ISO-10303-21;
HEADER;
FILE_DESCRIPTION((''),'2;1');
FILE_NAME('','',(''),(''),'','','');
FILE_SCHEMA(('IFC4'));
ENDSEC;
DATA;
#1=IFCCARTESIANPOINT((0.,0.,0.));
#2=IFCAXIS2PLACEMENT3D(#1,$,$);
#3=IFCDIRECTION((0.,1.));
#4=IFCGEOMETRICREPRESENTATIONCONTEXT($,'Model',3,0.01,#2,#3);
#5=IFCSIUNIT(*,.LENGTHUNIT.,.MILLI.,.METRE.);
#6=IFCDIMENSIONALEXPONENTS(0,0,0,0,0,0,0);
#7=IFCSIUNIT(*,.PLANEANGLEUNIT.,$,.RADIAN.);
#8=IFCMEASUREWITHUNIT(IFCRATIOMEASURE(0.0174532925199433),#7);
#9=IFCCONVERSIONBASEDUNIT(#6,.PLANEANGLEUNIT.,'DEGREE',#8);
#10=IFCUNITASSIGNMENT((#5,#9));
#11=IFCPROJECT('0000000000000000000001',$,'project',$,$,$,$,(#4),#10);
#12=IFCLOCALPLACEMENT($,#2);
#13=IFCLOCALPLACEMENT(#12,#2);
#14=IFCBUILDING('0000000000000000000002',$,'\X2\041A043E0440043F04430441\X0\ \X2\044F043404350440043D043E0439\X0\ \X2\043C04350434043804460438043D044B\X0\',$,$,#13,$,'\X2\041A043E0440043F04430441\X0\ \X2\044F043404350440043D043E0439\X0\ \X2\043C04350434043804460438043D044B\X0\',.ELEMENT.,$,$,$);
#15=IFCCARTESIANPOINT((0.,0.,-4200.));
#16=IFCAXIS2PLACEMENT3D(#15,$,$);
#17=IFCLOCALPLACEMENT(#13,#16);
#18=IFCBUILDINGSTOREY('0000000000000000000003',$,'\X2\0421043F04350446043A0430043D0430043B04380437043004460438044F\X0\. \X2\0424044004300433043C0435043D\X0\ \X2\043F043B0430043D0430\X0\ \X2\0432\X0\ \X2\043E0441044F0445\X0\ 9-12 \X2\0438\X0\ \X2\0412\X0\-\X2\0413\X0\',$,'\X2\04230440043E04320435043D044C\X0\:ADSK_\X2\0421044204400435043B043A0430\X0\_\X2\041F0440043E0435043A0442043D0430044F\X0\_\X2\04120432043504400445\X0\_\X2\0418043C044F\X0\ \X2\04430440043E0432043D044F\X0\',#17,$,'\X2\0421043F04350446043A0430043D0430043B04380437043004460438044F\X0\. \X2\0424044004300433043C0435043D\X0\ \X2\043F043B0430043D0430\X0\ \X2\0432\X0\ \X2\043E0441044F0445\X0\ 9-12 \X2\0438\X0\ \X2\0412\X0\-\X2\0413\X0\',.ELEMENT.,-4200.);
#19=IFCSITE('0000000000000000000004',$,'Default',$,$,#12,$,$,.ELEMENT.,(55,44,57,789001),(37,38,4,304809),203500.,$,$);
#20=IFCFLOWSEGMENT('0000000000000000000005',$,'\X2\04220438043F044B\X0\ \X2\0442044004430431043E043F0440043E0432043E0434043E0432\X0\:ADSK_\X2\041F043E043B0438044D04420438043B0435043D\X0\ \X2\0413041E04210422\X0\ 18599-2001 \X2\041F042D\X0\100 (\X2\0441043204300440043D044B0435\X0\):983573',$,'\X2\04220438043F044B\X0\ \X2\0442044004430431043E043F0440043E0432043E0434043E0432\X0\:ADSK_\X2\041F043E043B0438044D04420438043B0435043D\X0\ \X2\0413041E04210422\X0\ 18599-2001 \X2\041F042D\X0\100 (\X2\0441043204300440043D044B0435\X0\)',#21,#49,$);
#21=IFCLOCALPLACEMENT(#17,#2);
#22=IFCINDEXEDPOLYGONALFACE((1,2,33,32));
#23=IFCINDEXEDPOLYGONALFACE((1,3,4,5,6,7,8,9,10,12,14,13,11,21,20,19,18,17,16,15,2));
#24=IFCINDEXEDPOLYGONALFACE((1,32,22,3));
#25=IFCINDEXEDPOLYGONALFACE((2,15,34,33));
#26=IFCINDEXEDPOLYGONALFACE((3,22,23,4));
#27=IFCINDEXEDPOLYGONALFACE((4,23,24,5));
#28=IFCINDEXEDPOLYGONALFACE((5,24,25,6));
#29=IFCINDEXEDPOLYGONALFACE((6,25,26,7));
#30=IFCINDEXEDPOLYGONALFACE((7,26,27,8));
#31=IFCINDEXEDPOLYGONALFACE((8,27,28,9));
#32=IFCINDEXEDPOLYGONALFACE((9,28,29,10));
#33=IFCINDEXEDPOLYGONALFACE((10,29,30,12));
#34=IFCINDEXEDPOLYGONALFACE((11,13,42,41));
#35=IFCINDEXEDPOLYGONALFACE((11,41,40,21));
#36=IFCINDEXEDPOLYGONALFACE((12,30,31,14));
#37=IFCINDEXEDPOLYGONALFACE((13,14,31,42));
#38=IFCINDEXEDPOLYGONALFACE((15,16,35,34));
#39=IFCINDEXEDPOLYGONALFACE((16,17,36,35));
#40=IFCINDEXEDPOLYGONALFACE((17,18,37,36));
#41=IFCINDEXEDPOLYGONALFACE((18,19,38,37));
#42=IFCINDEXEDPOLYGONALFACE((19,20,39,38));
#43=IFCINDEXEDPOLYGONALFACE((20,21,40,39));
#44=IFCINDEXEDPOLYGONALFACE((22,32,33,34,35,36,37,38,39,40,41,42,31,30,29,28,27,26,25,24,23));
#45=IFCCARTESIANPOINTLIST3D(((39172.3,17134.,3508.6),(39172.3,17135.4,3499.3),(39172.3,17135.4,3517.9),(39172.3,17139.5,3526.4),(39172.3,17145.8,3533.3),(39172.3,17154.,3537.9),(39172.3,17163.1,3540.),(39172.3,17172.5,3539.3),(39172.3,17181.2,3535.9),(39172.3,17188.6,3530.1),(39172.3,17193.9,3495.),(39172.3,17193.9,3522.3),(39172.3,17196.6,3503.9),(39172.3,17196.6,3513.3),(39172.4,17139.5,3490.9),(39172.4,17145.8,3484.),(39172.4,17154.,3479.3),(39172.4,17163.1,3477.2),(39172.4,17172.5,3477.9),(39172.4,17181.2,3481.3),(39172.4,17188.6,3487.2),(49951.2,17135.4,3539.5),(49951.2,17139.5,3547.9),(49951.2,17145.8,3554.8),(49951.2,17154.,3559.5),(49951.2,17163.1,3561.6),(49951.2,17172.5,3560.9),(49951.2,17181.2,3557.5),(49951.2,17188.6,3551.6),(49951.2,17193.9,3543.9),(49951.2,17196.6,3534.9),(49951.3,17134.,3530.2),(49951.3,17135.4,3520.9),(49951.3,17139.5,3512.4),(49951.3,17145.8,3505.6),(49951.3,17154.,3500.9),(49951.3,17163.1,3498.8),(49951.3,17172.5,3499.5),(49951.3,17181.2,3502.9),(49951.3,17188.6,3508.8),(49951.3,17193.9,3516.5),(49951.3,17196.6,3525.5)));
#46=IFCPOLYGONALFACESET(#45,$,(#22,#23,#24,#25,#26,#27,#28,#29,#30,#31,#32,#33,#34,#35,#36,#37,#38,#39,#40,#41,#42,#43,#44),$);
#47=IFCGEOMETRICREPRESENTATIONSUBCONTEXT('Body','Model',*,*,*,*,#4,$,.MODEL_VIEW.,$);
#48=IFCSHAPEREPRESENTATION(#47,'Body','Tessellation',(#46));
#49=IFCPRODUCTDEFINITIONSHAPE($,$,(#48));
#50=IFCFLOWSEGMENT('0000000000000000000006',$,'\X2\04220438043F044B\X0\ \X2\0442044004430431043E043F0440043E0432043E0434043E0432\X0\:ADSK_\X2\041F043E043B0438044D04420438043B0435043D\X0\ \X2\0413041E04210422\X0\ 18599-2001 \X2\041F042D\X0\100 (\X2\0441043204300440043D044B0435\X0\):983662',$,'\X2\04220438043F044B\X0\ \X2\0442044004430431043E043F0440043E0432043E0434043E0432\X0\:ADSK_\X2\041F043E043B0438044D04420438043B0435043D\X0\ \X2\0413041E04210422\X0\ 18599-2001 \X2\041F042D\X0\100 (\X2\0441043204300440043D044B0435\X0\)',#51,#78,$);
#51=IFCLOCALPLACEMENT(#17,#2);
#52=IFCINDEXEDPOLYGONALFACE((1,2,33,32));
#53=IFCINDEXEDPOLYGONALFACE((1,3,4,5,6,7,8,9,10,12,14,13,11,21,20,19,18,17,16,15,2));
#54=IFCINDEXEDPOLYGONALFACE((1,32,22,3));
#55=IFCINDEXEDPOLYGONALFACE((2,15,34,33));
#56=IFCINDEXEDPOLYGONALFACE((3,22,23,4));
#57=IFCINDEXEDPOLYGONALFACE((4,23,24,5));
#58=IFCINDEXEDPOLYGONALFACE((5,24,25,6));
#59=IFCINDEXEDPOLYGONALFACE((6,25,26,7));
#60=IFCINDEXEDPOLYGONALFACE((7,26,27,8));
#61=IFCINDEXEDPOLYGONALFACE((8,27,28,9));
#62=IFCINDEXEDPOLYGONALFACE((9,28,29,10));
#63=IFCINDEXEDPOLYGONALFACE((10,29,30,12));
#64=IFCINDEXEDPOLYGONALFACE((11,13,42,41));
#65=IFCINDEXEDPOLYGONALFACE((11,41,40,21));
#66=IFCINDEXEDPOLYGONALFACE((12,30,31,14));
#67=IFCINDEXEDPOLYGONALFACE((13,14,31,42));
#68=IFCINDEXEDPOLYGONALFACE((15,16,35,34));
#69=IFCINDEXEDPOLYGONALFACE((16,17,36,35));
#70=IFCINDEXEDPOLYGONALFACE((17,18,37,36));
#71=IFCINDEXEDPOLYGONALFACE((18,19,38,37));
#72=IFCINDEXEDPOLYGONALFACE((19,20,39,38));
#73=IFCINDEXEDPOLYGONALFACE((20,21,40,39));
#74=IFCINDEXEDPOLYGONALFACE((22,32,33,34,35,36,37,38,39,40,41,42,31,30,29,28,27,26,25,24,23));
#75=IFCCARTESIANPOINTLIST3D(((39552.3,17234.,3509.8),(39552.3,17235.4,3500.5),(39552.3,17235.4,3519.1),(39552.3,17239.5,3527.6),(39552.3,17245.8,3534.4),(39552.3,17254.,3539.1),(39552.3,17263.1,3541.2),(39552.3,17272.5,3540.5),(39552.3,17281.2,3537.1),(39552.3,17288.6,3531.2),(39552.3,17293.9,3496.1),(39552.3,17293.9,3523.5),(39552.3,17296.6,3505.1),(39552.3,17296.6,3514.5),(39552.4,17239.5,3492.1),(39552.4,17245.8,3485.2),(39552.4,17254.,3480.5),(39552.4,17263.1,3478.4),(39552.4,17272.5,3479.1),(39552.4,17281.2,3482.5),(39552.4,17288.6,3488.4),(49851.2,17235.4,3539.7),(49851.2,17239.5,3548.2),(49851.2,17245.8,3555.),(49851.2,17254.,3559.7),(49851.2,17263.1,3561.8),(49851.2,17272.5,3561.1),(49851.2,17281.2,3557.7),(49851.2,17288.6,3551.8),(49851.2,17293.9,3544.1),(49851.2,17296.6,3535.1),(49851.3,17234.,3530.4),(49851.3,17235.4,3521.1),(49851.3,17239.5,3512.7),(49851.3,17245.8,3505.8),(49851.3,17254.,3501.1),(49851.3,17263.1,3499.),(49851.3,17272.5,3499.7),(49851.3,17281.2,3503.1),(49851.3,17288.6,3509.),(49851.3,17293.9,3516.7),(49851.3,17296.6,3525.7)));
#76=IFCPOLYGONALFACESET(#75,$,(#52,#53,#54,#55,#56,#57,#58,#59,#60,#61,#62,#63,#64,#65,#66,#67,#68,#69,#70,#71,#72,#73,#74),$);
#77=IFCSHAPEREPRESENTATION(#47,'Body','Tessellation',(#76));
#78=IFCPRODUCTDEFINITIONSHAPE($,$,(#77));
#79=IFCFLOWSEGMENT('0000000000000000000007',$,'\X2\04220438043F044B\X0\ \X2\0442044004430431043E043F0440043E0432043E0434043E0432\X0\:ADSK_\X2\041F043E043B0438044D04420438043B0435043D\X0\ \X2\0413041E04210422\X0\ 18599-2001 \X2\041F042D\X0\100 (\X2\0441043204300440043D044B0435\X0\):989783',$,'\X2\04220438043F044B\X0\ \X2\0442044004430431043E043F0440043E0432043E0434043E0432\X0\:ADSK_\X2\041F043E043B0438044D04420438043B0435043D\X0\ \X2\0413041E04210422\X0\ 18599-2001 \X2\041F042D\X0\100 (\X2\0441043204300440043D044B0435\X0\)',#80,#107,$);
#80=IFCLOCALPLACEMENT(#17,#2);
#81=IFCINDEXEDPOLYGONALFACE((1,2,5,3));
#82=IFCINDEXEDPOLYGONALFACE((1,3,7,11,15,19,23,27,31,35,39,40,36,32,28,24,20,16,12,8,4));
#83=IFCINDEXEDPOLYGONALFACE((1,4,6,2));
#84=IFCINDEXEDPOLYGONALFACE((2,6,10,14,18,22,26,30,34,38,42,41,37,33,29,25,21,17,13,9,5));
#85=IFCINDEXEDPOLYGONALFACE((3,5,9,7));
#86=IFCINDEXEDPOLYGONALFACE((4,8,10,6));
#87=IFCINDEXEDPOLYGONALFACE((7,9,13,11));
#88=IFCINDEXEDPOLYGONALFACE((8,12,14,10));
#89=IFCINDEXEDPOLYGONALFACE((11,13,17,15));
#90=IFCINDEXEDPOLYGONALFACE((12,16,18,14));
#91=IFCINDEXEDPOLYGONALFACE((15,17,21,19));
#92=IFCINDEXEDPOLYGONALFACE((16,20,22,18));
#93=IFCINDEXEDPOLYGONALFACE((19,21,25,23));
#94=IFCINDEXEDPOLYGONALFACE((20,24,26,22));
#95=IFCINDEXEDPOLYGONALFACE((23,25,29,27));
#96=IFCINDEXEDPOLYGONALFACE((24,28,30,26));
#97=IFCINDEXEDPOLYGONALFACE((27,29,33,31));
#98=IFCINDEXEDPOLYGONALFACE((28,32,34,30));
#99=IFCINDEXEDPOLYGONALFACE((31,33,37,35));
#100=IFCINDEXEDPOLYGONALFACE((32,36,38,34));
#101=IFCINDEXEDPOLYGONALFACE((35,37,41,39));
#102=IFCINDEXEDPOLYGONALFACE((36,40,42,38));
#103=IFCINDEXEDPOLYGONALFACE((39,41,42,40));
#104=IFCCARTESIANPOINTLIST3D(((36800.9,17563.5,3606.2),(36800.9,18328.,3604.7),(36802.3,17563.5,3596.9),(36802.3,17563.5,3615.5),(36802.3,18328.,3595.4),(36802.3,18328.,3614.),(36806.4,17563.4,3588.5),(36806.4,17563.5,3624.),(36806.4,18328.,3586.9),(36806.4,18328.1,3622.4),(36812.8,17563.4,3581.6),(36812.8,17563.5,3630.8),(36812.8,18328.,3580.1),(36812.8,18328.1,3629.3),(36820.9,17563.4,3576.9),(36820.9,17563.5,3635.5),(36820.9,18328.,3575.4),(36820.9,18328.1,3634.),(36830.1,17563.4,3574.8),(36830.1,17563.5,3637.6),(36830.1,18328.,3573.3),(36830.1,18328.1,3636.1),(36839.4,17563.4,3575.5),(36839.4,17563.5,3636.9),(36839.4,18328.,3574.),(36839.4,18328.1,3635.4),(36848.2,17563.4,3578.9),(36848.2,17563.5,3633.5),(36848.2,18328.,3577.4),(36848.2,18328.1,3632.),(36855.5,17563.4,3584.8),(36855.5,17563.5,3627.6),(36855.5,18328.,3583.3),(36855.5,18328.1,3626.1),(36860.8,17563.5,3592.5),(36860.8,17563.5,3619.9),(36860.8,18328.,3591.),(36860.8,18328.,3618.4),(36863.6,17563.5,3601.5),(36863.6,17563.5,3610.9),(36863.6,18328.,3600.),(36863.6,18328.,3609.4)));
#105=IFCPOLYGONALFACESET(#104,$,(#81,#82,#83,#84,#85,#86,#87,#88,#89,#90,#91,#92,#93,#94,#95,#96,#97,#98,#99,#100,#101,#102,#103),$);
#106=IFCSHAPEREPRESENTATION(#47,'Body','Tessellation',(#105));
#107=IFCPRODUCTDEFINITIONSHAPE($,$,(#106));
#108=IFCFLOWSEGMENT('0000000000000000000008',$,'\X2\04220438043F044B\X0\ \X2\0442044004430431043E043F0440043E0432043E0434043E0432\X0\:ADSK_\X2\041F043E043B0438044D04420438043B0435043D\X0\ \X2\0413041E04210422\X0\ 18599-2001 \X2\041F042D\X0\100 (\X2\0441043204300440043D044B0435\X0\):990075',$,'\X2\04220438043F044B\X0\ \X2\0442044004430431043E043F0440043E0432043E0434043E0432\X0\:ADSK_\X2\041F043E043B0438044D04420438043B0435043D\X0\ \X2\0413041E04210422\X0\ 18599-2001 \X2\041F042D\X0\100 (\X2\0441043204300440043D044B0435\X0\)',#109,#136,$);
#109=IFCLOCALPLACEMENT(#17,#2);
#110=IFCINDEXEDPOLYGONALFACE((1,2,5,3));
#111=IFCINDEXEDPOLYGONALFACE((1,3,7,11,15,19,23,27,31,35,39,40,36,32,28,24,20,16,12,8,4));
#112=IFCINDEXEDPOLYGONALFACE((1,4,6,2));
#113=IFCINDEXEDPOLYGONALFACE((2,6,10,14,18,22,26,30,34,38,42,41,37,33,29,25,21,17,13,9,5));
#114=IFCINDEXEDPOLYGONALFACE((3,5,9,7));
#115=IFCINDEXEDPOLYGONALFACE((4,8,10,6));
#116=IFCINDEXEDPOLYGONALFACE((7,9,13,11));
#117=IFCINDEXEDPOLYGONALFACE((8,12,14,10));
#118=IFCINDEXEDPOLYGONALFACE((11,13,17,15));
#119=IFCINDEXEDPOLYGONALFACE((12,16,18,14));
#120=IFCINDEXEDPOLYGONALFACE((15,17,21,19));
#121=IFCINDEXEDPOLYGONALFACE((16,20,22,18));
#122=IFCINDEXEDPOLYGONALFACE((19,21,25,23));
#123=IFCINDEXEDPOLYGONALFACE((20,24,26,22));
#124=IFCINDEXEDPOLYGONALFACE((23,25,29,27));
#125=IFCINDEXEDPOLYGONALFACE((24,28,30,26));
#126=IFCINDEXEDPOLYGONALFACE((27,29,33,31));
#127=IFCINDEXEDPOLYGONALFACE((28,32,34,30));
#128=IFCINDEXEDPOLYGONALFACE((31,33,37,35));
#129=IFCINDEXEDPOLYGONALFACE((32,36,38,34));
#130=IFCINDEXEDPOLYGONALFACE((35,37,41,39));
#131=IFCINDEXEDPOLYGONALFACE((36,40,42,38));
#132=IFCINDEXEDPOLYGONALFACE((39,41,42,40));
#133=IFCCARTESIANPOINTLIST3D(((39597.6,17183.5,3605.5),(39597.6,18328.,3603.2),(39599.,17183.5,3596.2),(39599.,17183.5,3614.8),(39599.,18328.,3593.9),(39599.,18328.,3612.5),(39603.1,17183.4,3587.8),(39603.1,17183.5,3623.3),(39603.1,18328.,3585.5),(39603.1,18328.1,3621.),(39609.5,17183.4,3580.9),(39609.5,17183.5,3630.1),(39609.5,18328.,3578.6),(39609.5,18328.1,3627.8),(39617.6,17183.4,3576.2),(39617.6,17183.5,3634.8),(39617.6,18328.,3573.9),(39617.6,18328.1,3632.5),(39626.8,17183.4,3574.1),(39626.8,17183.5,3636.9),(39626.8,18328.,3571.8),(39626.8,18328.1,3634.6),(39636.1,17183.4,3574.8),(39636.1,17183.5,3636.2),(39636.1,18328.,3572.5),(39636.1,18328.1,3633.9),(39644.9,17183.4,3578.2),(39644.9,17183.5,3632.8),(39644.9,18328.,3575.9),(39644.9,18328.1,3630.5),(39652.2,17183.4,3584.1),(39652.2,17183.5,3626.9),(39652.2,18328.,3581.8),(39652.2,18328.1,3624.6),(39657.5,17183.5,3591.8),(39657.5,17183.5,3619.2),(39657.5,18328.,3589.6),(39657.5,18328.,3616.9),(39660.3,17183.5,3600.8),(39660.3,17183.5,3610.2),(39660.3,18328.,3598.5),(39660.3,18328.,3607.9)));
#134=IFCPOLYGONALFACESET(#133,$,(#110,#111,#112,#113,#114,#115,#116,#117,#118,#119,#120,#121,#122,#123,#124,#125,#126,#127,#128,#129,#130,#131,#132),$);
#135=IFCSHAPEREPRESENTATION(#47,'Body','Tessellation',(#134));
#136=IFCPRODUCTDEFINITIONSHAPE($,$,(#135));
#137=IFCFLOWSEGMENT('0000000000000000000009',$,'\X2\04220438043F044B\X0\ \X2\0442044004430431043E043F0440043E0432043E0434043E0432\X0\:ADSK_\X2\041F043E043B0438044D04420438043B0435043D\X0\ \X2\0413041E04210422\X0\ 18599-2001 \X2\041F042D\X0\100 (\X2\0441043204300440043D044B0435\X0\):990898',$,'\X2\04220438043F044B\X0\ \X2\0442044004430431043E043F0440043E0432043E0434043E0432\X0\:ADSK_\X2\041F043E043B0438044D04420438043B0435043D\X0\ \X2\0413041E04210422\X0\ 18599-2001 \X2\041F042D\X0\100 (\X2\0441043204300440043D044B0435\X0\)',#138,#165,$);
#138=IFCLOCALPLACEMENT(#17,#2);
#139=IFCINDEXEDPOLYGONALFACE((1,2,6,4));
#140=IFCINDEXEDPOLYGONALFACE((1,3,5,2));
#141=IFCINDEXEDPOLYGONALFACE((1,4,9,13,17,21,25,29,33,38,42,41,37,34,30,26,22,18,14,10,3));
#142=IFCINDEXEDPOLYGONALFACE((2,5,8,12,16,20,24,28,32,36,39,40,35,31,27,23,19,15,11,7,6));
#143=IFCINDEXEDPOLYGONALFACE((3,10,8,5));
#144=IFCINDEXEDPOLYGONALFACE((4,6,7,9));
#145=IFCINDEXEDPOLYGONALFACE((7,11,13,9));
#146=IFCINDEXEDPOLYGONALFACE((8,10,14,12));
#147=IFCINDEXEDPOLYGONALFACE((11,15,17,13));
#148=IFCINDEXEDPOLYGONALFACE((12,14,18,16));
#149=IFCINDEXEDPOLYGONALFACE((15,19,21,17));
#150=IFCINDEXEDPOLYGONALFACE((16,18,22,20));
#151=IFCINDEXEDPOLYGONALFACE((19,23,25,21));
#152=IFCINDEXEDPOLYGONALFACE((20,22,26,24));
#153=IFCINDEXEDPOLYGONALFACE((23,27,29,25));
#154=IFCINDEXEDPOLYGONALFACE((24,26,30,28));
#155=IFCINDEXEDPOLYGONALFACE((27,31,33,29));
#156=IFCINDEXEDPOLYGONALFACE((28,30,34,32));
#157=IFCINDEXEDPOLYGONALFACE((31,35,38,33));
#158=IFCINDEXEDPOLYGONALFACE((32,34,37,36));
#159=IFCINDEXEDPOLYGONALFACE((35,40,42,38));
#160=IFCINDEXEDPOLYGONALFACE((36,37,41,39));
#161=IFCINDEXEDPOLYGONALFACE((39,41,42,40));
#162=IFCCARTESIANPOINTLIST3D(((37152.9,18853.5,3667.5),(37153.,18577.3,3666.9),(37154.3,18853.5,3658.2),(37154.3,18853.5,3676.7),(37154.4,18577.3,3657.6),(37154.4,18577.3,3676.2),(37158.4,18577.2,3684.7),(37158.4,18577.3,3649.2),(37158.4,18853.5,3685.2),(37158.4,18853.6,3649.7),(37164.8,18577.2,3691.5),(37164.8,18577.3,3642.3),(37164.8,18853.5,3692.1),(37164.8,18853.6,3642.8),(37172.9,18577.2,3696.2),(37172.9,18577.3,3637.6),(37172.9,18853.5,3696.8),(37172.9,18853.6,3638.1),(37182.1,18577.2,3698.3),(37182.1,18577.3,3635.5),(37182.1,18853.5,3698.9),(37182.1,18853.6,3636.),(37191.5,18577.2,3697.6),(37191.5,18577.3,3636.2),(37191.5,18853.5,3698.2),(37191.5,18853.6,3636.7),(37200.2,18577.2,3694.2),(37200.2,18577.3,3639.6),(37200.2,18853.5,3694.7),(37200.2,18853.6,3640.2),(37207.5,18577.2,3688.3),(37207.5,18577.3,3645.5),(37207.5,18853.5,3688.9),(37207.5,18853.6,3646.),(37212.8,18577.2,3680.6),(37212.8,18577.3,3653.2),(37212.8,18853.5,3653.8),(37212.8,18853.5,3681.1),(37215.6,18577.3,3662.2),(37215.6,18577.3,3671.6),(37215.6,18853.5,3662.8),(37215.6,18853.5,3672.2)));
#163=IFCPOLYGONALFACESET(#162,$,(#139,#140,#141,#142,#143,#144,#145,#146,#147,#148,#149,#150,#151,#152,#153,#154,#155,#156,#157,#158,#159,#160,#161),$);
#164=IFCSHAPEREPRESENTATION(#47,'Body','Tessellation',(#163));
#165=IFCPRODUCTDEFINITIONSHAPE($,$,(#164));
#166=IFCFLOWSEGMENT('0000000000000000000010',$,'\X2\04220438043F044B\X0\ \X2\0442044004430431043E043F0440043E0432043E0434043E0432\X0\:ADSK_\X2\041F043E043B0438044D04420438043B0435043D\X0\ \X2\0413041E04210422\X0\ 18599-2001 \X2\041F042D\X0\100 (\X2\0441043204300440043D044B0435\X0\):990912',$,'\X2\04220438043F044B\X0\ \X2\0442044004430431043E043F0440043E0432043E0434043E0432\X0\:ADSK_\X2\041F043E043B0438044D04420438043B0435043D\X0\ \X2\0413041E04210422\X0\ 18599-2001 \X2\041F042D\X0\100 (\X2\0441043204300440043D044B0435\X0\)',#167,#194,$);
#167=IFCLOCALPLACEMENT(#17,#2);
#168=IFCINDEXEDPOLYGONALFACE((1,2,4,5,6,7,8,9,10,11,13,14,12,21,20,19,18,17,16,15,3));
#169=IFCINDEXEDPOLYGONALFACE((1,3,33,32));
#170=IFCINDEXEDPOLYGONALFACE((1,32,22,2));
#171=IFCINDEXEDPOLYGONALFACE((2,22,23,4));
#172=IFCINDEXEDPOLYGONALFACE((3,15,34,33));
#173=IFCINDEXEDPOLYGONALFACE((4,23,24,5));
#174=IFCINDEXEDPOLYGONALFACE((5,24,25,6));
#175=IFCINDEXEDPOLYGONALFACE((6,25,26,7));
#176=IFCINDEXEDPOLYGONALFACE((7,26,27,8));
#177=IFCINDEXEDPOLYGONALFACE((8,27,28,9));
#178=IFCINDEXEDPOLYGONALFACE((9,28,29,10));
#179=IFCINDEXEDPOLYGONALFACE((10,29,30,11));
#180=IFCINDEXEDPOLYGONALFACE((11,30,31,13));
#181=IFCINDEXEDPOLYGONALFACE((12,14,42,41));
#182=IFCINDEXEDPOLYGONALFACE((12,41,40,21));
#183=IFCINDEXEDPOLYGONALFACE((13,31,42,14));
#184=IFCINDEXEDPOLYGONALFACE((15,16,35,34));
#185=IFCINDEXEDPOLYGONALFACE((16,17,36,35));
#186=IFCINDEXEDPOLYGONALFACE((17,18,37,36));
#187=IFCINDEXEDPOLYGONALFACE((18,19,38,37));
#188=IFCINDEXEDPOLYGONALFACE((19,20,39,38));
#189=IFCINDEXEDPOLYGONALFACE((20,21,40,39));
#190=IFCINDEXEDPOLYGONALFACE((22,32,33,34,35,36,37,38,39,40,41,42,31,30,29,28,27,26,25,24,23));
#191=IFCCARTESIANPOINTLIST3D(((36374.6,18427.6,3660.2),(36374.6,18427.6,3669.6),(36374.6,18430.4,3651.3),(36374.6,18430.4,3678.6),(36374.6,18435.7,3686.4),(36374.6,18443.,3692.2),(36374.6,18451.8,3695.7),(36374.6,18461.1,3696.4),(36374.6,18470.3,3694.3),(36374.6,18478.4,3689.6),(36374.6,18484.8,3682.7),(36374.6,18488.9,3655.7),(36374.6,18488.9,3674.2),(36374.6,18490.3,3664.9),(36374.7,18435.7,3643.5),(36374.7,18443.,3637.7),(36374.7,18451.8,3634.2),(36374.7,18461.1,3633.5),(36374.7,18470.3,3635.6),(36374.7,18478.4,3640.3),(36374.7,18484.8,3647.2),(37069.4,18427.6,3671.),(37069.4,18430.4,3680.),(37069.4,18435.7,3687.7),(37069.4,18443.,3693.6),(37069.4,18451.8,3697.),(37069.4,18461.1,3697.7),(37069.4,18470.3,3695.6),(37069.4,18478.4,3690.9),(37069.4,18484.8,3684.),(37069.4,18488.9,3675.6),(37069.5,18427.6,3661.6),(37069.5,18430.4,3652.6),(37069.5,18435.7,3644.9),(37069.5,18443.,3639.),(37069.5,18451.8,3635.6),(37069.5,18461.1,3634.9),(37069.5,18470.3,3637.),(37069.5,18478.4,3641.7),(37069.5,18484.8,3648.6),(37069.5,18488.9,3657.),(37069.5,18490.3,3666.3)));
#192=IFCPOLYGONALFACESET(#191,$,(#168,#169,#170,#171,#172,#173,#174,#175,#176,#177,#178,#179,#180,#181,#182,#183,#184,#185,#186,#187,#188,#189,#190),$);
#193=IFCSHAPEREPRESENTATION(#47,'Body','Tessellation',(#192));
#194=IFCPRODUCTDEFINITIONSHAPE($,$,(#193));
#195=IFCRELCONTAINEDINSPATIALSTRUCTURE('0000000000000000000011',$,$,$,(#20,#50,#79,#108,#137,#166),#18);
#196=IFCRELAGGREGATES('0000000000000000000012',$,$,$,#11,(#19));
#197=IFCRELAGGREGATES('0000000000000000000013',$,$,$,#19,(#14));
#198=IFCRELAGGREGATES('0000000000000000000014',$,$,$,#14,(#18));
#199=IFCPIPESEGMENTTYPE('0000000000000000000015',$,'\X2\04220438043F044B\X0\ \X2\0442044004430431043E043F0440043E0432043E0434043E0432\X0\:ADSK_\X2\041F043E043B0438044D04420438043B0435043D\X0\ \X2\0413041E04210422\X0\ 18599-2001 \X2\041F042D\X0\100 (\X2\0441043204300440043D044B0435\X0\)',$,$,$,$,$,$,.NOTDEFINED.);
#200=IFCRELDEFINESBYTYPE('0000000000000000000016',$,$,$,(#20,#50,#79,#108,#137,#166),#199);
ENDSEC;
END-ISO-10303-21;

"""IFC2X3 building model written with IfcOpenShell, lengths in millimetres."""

from ifc_helpers import new_model, entity, si_unit, converted_unit, direction, frame, frame_2d, origin, origin_2d_with_axis, place, context, subcontext, project, spatial, circle, extrude, type_object, element, save


model = new_model("IFC2X3")

# Units and contexts
model_context = context("Model", 3, precision=0.01, world=origin(), true_north=direction((0.0, 1.0)))
body_context = subcontext(model_context, "Body", "Model", "MODEL_VIEW")
ifc_project = project(units=[si_unit("LENGTHUNIT", "METRE", prefix="MILLI"), converted_unit("PLANEANGLEUNIT", "DEGREE", entity("IfcRatioMeasure", 0.0174532925199433), si_unit("PLANEANGLEUNIT", "RADIAN"), dimensions=[0, 0, 0, 0, 0, 0, 0])], contexts=[model_context])

# Site, building, storey
site_placement = place(None, frame((0.0, 0.0, 0.0)))
site = spatial("IfcSite", under=ifc_project, at=site_placement, Name="Default", CompositionType="ELEMENT", RefLatitude=(55, 44, 57, 789001), RefLongitude=(37, 38, 4, 304809), RefElevation=203500.0)
building_placement = place(site_placement, origin())
building = spatial("IfcBuilding", under=site, at=building_placement, Name="Корпус ядерной медицины", LongName="Корпус ядерной медицины", CompositionType="ELEMENT")
storey_placement = place(building_placement, frame((0.0, 0.0, -4200.0)))
storey = spatial("IfcBuildingStorey", under=building, at=storey_placement, Name="Спецканализация. Фрагмен плана в осях 9-12 и В-Г", ObjectType="Уровень:ADSK_Стрелка_Проектная_Вверх_Имя уровня", LongName="Спецканализация. Фрагмен плана в осях 9-12 и В-Г", CompositionType="ELEMENT", Elevation=-4200.0)

# Flow segments
pipe_segment_type = type_object("IfcPipeSegmentType", Name="Типы трубопроводов:ADSK_Полиэтилен ГОСТ 18599-2001 ПЭ100 (сварные)", PredefinedType="NOTDEFINED")
flow_segment_1_placement = place(storey_placement, frame((39172.3, 17132.4, 3475.5)))
element("IfcFlowSegment", 1, at=flow_segment_1_placement, inside=storey, type_object=pipe_segment_type, Name="Типы трубопроводов:ADSK_Полиэтилен ГОСТ 18599-2001 ПЭ100 (сварные):983573", ObjectType="Типы трубопроводов:ADSK_Полиэтилен ГОСТ 18599-2001 ПЭ100 (сварные)", context=body_context, shape_type="SweptSolid", body=[
    extrude(circle(Radius=31.5, at=origin_2d_with_axis()), frame((0.1, 33.1, 33.1), z_axis=(0.999998, 0.0, 0.002), x_axis=(0.0, -1.0, 0.0)), (0.0, 0.0, 1.0), 10779.0),
])
flow_segment_2_placement = place(storey_placement, frame((39552.3, 17232.4, 3476.7)))
element("IfcFlowSegment", 2, at=flow_segment_2_placement, inside=storey, type_object=pipe_segment_type, Name="Типы трубопроводов:ADSK_Полиэтилен ГОСТ 18599-2001 ПЭ100 (сварные):983662", ObjectType="Типы трубопроводов:ADSK_Полиэтилен ГОСТ 18599-2001 ПЭ100 (сварные)", context=body_context, shape_type="SweptSolid", body=[
    extrude(circle(Radius=31.5, at=frame_2d((0.0, 0.0), x_axis=(1.0, 0.0))), frame((0.1, 33.1, 33.1), z_axis=(0.999998, 0.0, 0.002), x_axis=(0.0, -1.0, 0.0)), (0.0, 0.0, 1.0), 10299.0),
])
flow_segment_3_placement = place(storey_placement, frame((36799.3, 17563.4, 3571.6)))
element("IfcFlowSegment", 3, at=flow_segment_3_placement, inside=storey, type_object=pipe_segment_type, Name="Типы трубопроводов:ADSK_Полиэтилен ГОСТ 18599-2001 ПЭ100 (сварные):989783", ObjectType="Типы трубопроводов:ADSK_Полиэтилен ГОСТ 18599-2001 ПЭ100 (сварные)", context=body_context, shape_type="SweptSolid", body=[
    extrude(circle(Radius=31.5, at=frame_2d((0.0, 0.0), x_axis=(1.0, 0.0))), frame((33.1, 764.6, 33.1), z_axis=(0.0, -0.999998, 0.002), x_axis=(-1.0, 0.0, 0.0)), (0.0, 0.0, 1.0), 764.5),
])
flow_segment_4_placement = place(storey_placement, frame((39596.0, 17183.4, 3570.1)))
element("IfcFlowSegment", 4, at=flow_segment_4_placement, inside=storey, type_object=pipe_segment_type, Name="Типы трубопроводов:ADSK_Полиэтилен ГОСТ 18599-2001 ПЭ100 (сварные):990075", ObjectType="Типы трубопроводов:ADSK_Полиэтилен ГОСТ 18599-2001 ПЭ100 (сварные)", context=body_context, shape_type="SweptSolid", body=[
    extrude(circle(Radius=31.5, at=origin_2d_with_axis()), frame((33.1, 1144.6, 33.1), z_axis=(0.0, -0.999998, 0.002), x_axis=(-1.0, 0.0, 0.0)), (0.0, 0.0, 1.0), 1144.5),
])
flow_segment_5_placement = place(storey_placement, frame((37151.4, 18577.2, 3633.8)))
element("IfcFlowSegment", 5, at=flow_segment_5_placement, inside=storey, type_object=pipe_segment_type, Name="Типы трубопроводов:ADSK_Полиэтилен ГОСТ 18599-2001 ПЭ100 (сварные):990898", ObjectType="Типы трубопроводов:ADSK_Полиэтилен ГОСТ 18599-2001 ПЭ100 (сварные)", context=body_context, shape_type="SweptSolid", body=[
    extrude(circle(Radius=31.5, at=frame_2d((0.0, 0.0), x_axis=(1.0, 0.0))), frame((33.1, 0.1, 33.1), z_axis=(-0.000004, 0.999998, 0.002), x_axis=(-1.0, -0.000004, 0.0)), (0.0, 0.0, 1.0), 276.2),
])
flow_segment_6_placement = place(storey_placement, frame((36374.6, 18425.7, 3631.8)))
element("IfcFlowSegment", 6, at=flow_segment_6_placement, inside=storey, type_object=pipe_segment_type, Name="Типы трубопроводов:ADSK_Полиэтилен ГОСТ 18599-2001 ПЭ100 (сварные):990912", ObjectType="Типы трубопроводов:ADSK_Полиэтилен ГОСТ 18599-2001 ПЭ100 (сварные)", context=body_context, shape_type="SweptSolid", body=[
    extrude(circle(Radius=31.5, at=origin_2d_with_axis()), frame((0.1, 33.1, 33.1), z_axis=(0.999998, 0.0, 0.001954), x_axis=(0.0, 1.0, 0.0)), (0.0, 0.0, 1.0), 694.8),
])

save(model, "model.ifc")
